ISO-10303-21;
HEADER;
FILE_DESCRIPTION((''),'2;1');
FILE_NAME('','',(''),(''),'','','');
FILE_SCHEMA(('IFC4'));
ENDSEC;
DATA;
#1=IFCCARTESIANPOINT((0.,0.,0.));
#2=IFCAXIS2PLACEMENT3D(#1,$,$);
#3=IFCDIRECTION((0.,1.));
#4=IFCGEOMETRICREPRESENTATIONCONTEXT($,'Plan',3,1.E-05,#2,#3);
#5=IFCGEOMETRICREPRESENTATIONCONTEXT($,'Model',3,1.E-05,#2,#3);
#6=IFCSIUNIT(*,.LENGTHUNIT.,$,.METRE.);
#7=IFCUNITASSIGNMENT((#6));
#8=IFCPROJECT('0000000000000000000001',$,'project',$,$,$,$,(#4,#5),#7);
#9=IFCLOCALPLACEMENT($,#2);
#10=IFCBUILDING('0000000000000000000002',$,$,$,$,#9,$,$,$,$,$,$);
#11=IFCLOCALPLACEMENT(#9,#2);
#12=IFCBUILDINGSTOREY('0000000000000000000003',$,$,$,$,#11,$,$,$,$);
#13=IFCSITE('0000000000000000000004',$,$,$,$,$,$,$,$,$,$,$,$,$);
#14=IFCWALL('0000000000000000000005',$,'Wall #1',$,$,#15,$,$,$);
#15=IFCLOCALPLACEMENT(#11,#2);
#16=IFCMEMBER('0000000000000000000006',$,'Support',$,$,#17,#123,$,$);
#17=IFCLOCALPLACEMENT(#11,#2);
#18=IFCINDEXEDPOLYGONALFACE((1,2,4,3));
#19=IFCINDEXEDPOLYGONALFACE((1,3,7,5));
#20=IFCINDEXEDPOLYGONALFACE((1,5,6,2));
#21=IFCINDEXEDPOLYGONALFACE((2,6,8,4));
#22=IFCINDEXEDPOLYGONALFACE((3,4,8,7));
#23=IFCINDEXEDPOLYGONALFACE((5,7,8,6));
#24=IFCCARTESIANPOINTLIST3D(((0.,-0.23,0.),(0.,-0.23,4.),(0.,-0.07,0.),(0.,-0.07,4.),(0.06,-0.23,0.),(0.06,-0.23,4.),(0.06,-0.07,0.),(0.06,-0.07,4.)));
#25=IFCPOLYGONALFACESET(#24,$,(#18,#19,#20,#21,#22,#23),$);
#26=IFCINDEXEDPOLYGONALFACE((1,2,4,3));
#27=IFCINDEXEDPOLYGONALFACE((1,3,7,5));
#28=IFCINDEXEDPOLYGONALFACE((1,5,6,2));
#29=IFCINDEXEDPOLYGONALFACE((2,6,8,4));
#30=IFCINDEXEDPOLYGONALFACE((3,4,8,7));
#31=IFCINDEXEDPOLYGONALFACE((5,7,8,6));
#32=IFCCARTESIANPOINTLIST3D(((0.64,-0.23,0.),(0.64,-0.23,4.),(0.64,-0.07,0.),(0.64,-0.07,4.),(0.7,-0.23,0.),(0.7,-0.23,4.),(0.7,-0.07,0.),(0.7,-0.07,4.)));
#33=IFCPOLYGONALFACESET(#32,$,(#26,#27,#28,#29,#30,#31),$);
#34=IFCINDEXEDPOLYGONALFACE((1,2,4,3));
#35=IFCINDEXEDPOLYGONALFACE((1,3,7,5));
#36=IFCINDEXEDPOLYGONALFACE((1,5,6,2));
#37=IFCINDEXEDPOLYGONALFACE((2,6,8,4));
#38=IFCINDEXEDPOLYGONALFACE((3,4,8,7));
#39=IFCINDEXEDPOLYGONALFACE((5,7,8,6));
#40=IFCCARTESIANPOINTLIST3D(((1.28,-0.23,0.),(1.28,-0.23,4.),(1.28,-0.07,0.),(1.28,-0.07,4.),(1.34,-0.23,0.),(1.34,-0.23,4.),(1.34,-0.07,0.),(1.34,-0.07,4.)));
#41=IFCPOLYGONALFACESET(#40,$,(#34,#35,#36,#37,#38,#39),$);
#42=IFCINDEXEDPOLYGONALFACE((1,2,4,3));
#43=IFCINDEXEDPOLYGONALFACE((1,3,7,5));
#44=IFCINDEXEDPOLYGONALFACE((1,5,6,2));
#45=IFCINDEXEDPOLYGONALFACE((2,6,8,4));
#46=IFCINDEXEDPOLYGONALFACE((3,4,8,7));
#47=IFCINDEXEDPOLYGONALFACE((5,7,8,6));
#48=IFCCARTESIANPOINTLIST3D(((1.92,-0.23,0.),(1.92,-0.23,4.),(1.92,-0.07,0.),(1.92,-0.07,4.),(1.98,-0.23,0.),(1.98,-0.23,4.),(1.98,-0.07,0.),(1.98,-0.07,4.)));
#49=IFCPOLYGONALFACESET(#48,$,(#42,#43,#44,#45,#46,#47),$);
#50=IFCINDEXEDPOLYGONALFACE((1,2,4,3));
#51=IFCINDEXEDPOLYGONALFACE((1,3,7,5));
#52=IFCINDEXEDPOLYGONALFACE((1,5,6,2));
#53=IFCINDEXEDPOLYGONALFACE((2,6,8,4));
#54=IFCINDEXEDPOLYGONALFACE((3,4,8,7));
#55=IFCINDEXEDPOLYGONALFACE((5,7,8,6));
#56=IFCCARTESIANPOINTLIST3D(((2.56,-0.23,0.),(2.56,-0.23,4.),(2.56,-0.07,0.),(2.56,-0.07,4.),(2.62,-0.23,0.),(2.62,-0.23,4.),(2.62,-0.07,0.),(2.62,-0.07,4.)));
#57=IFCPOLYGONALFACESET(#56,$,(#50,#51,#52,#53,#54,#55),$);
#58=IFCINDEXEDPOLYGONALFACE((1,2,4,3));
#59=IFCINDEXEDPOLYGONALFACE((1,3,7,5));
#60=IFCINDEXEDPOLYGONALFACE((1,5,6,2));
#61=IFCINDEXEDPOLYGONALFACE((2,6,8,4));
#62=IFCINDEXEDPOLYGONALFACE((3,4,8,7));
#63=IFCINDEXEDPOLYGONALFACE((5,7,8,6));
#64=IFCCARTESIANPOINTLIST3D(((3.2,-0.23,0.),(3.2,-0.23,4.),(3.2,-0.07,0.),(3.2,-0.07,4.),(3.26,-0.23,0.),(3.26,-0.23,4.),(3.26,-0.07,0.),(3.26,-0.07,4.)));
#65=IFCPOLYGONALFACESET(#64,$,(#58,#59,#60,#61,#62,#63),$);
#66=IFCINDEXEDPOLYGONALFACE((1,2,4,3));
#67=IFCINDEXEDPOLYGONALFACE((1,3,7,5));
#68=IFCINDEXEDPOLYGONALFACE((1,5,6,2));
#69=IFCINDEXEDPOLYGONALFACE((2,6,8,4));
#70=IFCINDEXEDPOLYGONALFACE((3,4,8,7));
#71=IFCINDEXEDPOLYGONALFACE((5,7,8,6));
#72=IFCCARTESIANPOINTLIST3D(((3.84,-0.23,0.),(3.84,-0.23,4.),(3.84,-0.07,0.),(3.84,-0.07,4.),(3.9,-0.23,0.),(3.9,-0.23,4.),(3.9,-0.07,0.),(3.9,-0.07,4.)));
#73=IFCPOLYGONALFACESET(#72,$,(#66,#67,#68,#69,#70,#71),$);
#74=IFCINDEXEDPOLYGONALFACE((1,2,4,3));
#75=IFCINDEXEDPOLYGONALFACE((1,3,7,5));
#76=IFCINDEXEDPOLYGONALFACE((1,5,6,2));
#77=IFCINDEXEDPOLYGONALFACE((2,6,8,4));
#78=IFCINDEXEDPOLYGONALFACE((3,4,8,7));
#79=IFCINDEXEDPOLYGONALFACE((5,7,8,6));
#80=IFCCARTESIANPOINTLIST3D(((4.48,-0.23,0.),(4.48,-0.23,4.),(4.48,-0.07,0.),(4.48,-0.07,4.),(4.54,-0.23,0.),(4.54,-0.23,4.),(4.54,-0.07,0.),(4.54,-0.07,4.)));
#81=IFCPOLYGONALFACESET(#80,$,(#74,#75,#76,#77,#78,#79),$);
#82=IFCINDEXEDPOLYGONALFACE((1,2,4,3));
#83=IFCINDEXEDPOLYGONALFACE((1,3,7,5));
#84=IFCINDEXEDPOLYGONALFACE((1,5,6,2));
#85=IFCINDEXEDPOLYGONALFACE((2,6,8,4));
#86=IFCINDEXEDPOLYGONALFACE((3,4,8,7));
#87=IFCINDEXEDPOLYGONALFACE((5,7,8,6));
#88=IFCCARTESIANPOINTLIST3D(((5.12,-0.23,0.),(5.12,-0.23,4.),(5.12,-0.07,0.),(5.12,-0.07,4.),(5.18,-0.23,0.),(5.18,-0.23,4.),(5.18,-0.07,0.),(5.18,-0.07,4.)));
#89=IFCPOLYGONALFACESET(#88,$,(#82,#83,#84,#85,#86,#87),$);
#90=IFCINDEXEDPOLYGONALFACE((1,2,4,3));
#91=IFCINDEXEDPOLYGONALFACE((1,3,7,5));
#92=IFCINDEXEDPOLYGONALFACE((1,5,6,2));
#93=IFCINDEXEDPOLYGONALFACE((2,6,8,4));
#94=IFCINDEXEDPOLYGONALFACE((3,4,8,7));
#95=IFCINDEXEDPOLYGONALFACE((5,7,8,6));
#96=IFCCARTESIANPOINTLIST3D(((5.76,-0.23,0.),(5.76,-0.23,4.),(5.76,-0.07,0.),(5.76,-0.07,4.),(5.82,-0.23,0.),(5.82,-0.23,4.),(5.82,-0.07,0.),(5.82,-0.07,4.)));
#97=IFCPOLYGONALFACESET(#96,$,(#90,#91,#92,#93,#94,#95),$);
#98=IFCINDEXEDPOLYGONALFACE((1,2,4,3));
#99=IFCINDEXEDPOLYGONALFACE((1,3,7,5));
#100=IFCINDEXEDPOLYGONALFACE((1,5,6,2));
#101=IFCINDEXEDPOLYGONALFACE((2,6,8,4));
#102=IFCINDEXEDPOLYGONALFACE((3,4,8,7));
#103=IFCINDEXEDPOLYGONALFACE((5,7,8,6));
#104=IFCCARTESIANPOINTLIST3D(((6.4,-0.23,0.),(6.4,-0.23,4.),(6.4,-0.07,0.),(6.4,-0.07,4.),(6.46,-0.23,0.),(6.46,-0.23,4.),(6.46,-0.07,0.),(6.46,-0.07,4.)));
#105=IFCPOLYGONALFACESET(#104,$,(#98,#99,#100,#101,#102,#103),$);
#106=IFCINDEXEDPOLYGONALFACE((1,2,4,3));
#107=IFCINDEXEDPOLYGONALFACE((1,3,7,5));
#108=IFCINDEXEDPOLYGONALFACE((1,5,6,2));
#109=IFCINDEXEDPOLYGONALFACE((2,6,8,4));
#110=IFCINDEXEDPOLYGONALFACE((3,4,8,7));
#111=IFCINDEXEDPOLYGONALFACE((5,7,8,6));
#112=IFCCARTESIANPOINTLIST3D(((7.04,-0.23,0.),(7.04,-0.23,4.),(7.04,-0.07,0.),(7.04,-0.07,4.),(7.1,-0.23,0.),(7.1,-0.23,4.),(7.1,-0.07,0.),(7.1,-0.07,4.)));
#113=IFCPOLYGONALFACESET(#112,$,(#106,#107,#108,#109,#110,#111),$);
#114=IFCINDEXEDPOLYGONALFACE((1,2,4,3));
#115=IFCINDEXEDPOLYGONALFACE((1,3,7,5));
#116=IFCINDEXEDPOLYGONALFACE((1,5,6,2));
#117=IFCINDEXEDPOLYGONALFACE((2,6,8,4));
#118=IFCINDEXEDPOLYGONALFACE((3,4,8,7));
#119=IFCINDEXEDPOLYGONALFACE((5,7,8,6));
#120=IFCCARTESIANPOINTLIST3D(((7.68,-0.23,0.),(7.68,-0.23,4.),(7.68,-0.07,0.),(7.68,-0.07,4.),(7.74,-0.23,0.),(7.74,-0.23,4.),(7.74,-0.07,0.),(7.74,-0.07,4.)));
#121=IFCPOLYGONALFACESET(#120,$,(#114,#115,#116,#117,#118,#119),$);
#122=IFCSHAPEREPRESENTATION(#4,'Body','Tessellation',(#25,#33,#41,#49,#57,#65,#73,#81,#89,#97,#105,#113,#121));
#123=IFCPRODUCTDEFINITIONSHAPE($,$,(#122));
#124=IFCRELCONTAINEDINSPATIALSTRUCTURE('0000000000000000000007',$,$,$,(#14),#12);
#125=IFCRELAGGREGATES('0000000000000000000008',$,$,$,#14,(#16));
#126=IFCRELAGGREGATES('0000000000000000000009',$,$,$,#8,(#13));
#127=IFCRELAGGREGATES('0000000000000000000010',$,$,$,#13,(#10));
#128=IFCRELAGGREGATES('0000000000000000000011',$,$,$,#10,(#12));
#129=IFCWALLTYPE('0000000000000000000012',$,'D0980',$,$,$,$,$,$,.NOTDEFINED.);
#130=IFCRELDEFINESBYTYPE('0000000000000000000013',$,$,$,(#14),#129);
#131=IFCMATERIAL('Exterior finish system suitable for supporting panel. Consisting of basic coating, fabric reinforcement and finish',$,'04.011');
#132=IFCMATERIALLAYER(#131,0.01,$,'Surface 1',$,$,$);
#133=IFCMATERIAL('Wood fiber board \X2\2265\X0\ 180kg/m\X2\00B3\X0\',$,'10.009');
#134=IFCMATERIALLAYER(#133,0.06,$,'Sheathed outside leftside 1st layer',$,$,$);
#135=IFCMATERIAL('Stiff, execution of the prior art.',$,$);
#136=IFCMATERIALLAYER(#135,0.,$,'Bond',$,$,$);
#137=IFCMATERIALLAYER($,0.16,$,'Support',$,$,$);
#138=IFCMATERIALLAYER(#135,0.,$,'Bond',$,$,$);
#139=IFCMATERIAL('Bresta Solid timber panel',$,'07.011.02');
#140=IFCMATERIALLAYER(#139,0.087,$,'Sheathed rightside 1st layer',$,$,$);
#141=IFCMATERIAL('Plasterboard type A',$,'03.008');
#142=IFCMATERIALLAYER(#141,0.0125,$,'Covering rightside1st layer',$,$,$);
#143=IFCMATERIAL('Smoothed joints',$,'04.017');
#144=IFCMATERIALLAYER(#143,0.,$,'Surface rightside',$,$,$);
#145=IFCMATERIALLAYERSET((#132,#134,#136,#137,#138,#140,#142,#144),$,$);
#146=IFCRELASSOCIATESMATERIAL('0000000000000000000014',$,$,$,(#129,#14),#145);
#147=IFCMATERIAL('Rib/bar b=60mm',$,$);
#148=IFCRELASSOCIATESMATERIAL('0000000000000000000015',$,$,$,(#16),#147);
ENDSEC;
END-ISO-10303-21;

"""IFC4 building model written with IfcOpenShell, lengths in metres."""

from ifc_helpers import new_model, si_unit, direction, frame, frame_2d, origin, place, context, project, spatial, rectangle, extrude, material, layer, layer_set, type_object, element, aggregate, save


model = new_model("IFC4")

# Units and contexts
plan_context = context("Plan", 3, precision=1e-05, world=origin(), true_north=direction((0.0, 1.0)))
model_context = context("Model", 3, precision=1e-05, world=origin(), true_north=direction((0.0, 1.0)))
ifc_project = project(units=[si_unit("LENGTHUNIT", "METRE")], contexts=[plan_context, model_context])

# Site, building, storey
site = spatial("IfcSite", under=ifc_project)
building_placement = place(None, origin())
building = spatial("IfcBuilding", under=site, at=building_placement)
storey_placement = place(building_placement, origin())
storey = spatial("IfcBuildingStorey", under=building, at=storey_placement)

# Wall, member
ifc_material_1 = material(Name="Exterior finish system suitable for supporting panel. Consisting of basic coating, fabric reinforcement and finish", Category="04.011")
ifc_layer_1 = layer(ifc_material_1, 0.01, Name="Surface 1")
ifc_material_2 = material(Name="Wood fiber board ≥ 180kg/m³", Category="10.009")
ifc_layer_2 = layer(ifc_material_2, 0.06, Name="Sheathed outside leftside 1st layer")
ifc_material_3 = material(Name="Stiff, execution of the prior art.")
ifc_layer_3 = layer(ifc_material_3, 0.0, Name="Bond")
ifc_layer_4 = layer(None, 0.16, Name="Support")
ifc_layer_5 = layer(ifc_material_3, 0.0, Name="Bond")
ifc_material_4 = material(Name="Bresta Solid timber panel", Category="07.011.02")
ifc_layer_6 = layer(ifc_material_4, 0.087, Name="Sheathed rightside 1st layer")
ifc_material_5 = material(Name="Plasterboard type A", Category="03.008")
ifc_layer_7 = layer(ifc_material_5, 0.0125, Name="Covering rightside1st layer")
ifc_material_6 = material(Name="Smoothed joints", Category="04.017")
ifc_layer_8 = layer(ifc_material_6, 0.0, Name="Surface rightside")
ifc_layer_set = layer_set([ifc_layer_1, ifc_layer_2, ifc_layer_3, ifc_layer_4, ifc_layer_5, ifc_layer_6, ifc_layer_7, ifc_layer_8])
wall_type = type_object("IfcWallType", Name="D0980", PredefinedType="NOTDEFINED", material=ifc_layer_set)
wall_placement = place(None, frame((0.0, 0.0, 0.0), z_axis=(0.0, -1.0, 0.0), x_axis=(1.0, 0.0, 0.0)))
wall = element("IfcWall", 1, at=wall_placement, inside=storey, type_object=wall_type, material=ifc_layer_set, Name="Wall #1")
ifc_material_7 = material(Name="Rib/bar b=60mm")
member_1_placement = place(wall_placement, origin())
member_1 = element("IfcMember", 2, at=member_1_placement, material=ifc_material_7, Name="Support", context=plan_context, shape_type="SweptSolid", body=[
    extrude(rectangle(XDim=0.06, YDim=0.16, at=frame_2d((0.03, 0.08), x_axis=(1.0, 0.0))), frame((0.0, 4.0, 0.07), z_axis=(0.0, -1.0, 0.0), x_axis=(1.0, 0.0, 0.0)), (0.0, 0.0, 1.0), 4.0),
    extrude(rectangle(XDim=0.06, YDim=0.16, at=frame_2d((0.03, 0.08), x_axis=(1.0, 0.0))), frame((0.64, 4.0, 0.07), z_axis=(0.0, -1.0, 0.0), x_axis=(1.0, 0.0, 0.0)), (0.0, 0.0, 1.0), 4.0),
    extrude(rectangle(XDim=0.06, YDim=0.16, at=frame_2d((0.03, 0.08), x_axis=(1.0, 0.0))), frame((1.28, 4.0, 0.07), z_axis=(0.0, -1.0, 0.0), x_axis=(1.0, 0.0, 0.0)), (0.0, 0.0, 1.0), 4.0),
    extrude(rectangle(XDim=0.06, YDim=0.16, at=frame_2d((0.03, 0.08), x_axis=(1.0, 0.0))), frame((1.92, 4.0, 0.07), z_axis=(0.0, -1.0, 0.0), x_axis=(1.0, 0.0, 0.0)), (0.0, 0.0, 1.0), 4.0),
    extrude(rectangle(XDim=0.06, YDim=0.16, at=frame_2d((0.03, 0.08), x_axis=(1.0, 0.0))), frame((2.56, 4.0, 0.07), z_axis=(0.0, -1.0, 0.0), x_axis=(1.0, 0.0, 0.0)), (0.0, 0.0, 1.0), 4.0),
    extrude(rectangle(XDim=0.06, YDim=0.16, at=frame_2d((0.03, 0.08), x_axis=(1.0, 0.0))), frame((3.2, 4.0, 0.07), z_axis=(0.0, -1.0, 0.0), x_axis=(1.0, 0.0, 0.0)), (0.0, 0.0, 1.0), 4.0),
    extrude(rectangle(XDim=0.06, YDim=0.16, at=frame_2d((0.03, 0.08), x_axis=(1.0, 0.0))), frame((3.84, 4.0, 0.07), z_axis=(0.0, -1.0, 0.0), x_axis=(1.0, 0.0, 0.0)), (0.0, 0.0, 1.0), 4.0),
    extrude(rectangle(XDim=0.06, YDim=0.16, at=frame_2d((0.03, 0.08), x_axis=(1.0, 0.0))), frame((4.48, 4.0, 0.07), z_axis=(0.0, -1.0, 0.0), x_axis=(1.0, 0.0, 0.0)), (0.0, 0.0, 1.0), 4.0),
    extrude(rectangle(XDim=0.06, YDim=0.16, at=frame_2d((0.03, 0.08), x_axis=(1.0, 0.0))), frame((5.12, 4.0, 0.07), z_axis=(0.0, -1.0, 0.0), x_axis=(1.0, 0.0, 0.0)), (0.0, 0.0, 1.0), 4.0),
    extrude(rectangle(XDim=0.06, YDim=0.16, at=frame_2d((0.03, 0.08), x_axis=(1.0, 0.0))), frame((5.76, 4.0, 0.07), z_axis=(0.0, -1.0, 0.0), x_axis=(1.0, 0.0, 0.0)), (0.0, 0.0, 1.0), 4.0),
    extrude(rectangle(XDim=0.06, YDim=0.16, at=frame_2d((0.03, 0.08), x_axis=(1.0, 0.0))), frame((6.4, 4.0, 0.07), z_axis=(0.0, -1.0, 0.0), x_axis=(1.0, 0.0, 0.0)), (0.0, 0.0, 1.0), 4.0),
    extrude(rectangle(XDim=0.06, YDim=0.16, at=frame_2d((0.03, 0.08), x_axis=(1.0, 0.0))), frame((7.04, 4.0, 0.07), z_axis=(0.0, -1.0, 0.0), x_axis=(1.0, 0.0, 0.0)), (0.0, 0.0, 1.0), 4.0),
    extrude(rectangle(XDim=0.06, YDim=0.16, at=frame_2d((0.03, 0.08), x_axis=(1.0, 0.0))), frame((7.68, 4.0, 0.07), z_axis=(0.0, -1.0, 0.0), x_axis=(1.0, 0.0, 0.0)), (0.0, 0.0, 1.0), 4.0),
])
aggregate(wall, [member_1])

save(model, "model.ifc")
